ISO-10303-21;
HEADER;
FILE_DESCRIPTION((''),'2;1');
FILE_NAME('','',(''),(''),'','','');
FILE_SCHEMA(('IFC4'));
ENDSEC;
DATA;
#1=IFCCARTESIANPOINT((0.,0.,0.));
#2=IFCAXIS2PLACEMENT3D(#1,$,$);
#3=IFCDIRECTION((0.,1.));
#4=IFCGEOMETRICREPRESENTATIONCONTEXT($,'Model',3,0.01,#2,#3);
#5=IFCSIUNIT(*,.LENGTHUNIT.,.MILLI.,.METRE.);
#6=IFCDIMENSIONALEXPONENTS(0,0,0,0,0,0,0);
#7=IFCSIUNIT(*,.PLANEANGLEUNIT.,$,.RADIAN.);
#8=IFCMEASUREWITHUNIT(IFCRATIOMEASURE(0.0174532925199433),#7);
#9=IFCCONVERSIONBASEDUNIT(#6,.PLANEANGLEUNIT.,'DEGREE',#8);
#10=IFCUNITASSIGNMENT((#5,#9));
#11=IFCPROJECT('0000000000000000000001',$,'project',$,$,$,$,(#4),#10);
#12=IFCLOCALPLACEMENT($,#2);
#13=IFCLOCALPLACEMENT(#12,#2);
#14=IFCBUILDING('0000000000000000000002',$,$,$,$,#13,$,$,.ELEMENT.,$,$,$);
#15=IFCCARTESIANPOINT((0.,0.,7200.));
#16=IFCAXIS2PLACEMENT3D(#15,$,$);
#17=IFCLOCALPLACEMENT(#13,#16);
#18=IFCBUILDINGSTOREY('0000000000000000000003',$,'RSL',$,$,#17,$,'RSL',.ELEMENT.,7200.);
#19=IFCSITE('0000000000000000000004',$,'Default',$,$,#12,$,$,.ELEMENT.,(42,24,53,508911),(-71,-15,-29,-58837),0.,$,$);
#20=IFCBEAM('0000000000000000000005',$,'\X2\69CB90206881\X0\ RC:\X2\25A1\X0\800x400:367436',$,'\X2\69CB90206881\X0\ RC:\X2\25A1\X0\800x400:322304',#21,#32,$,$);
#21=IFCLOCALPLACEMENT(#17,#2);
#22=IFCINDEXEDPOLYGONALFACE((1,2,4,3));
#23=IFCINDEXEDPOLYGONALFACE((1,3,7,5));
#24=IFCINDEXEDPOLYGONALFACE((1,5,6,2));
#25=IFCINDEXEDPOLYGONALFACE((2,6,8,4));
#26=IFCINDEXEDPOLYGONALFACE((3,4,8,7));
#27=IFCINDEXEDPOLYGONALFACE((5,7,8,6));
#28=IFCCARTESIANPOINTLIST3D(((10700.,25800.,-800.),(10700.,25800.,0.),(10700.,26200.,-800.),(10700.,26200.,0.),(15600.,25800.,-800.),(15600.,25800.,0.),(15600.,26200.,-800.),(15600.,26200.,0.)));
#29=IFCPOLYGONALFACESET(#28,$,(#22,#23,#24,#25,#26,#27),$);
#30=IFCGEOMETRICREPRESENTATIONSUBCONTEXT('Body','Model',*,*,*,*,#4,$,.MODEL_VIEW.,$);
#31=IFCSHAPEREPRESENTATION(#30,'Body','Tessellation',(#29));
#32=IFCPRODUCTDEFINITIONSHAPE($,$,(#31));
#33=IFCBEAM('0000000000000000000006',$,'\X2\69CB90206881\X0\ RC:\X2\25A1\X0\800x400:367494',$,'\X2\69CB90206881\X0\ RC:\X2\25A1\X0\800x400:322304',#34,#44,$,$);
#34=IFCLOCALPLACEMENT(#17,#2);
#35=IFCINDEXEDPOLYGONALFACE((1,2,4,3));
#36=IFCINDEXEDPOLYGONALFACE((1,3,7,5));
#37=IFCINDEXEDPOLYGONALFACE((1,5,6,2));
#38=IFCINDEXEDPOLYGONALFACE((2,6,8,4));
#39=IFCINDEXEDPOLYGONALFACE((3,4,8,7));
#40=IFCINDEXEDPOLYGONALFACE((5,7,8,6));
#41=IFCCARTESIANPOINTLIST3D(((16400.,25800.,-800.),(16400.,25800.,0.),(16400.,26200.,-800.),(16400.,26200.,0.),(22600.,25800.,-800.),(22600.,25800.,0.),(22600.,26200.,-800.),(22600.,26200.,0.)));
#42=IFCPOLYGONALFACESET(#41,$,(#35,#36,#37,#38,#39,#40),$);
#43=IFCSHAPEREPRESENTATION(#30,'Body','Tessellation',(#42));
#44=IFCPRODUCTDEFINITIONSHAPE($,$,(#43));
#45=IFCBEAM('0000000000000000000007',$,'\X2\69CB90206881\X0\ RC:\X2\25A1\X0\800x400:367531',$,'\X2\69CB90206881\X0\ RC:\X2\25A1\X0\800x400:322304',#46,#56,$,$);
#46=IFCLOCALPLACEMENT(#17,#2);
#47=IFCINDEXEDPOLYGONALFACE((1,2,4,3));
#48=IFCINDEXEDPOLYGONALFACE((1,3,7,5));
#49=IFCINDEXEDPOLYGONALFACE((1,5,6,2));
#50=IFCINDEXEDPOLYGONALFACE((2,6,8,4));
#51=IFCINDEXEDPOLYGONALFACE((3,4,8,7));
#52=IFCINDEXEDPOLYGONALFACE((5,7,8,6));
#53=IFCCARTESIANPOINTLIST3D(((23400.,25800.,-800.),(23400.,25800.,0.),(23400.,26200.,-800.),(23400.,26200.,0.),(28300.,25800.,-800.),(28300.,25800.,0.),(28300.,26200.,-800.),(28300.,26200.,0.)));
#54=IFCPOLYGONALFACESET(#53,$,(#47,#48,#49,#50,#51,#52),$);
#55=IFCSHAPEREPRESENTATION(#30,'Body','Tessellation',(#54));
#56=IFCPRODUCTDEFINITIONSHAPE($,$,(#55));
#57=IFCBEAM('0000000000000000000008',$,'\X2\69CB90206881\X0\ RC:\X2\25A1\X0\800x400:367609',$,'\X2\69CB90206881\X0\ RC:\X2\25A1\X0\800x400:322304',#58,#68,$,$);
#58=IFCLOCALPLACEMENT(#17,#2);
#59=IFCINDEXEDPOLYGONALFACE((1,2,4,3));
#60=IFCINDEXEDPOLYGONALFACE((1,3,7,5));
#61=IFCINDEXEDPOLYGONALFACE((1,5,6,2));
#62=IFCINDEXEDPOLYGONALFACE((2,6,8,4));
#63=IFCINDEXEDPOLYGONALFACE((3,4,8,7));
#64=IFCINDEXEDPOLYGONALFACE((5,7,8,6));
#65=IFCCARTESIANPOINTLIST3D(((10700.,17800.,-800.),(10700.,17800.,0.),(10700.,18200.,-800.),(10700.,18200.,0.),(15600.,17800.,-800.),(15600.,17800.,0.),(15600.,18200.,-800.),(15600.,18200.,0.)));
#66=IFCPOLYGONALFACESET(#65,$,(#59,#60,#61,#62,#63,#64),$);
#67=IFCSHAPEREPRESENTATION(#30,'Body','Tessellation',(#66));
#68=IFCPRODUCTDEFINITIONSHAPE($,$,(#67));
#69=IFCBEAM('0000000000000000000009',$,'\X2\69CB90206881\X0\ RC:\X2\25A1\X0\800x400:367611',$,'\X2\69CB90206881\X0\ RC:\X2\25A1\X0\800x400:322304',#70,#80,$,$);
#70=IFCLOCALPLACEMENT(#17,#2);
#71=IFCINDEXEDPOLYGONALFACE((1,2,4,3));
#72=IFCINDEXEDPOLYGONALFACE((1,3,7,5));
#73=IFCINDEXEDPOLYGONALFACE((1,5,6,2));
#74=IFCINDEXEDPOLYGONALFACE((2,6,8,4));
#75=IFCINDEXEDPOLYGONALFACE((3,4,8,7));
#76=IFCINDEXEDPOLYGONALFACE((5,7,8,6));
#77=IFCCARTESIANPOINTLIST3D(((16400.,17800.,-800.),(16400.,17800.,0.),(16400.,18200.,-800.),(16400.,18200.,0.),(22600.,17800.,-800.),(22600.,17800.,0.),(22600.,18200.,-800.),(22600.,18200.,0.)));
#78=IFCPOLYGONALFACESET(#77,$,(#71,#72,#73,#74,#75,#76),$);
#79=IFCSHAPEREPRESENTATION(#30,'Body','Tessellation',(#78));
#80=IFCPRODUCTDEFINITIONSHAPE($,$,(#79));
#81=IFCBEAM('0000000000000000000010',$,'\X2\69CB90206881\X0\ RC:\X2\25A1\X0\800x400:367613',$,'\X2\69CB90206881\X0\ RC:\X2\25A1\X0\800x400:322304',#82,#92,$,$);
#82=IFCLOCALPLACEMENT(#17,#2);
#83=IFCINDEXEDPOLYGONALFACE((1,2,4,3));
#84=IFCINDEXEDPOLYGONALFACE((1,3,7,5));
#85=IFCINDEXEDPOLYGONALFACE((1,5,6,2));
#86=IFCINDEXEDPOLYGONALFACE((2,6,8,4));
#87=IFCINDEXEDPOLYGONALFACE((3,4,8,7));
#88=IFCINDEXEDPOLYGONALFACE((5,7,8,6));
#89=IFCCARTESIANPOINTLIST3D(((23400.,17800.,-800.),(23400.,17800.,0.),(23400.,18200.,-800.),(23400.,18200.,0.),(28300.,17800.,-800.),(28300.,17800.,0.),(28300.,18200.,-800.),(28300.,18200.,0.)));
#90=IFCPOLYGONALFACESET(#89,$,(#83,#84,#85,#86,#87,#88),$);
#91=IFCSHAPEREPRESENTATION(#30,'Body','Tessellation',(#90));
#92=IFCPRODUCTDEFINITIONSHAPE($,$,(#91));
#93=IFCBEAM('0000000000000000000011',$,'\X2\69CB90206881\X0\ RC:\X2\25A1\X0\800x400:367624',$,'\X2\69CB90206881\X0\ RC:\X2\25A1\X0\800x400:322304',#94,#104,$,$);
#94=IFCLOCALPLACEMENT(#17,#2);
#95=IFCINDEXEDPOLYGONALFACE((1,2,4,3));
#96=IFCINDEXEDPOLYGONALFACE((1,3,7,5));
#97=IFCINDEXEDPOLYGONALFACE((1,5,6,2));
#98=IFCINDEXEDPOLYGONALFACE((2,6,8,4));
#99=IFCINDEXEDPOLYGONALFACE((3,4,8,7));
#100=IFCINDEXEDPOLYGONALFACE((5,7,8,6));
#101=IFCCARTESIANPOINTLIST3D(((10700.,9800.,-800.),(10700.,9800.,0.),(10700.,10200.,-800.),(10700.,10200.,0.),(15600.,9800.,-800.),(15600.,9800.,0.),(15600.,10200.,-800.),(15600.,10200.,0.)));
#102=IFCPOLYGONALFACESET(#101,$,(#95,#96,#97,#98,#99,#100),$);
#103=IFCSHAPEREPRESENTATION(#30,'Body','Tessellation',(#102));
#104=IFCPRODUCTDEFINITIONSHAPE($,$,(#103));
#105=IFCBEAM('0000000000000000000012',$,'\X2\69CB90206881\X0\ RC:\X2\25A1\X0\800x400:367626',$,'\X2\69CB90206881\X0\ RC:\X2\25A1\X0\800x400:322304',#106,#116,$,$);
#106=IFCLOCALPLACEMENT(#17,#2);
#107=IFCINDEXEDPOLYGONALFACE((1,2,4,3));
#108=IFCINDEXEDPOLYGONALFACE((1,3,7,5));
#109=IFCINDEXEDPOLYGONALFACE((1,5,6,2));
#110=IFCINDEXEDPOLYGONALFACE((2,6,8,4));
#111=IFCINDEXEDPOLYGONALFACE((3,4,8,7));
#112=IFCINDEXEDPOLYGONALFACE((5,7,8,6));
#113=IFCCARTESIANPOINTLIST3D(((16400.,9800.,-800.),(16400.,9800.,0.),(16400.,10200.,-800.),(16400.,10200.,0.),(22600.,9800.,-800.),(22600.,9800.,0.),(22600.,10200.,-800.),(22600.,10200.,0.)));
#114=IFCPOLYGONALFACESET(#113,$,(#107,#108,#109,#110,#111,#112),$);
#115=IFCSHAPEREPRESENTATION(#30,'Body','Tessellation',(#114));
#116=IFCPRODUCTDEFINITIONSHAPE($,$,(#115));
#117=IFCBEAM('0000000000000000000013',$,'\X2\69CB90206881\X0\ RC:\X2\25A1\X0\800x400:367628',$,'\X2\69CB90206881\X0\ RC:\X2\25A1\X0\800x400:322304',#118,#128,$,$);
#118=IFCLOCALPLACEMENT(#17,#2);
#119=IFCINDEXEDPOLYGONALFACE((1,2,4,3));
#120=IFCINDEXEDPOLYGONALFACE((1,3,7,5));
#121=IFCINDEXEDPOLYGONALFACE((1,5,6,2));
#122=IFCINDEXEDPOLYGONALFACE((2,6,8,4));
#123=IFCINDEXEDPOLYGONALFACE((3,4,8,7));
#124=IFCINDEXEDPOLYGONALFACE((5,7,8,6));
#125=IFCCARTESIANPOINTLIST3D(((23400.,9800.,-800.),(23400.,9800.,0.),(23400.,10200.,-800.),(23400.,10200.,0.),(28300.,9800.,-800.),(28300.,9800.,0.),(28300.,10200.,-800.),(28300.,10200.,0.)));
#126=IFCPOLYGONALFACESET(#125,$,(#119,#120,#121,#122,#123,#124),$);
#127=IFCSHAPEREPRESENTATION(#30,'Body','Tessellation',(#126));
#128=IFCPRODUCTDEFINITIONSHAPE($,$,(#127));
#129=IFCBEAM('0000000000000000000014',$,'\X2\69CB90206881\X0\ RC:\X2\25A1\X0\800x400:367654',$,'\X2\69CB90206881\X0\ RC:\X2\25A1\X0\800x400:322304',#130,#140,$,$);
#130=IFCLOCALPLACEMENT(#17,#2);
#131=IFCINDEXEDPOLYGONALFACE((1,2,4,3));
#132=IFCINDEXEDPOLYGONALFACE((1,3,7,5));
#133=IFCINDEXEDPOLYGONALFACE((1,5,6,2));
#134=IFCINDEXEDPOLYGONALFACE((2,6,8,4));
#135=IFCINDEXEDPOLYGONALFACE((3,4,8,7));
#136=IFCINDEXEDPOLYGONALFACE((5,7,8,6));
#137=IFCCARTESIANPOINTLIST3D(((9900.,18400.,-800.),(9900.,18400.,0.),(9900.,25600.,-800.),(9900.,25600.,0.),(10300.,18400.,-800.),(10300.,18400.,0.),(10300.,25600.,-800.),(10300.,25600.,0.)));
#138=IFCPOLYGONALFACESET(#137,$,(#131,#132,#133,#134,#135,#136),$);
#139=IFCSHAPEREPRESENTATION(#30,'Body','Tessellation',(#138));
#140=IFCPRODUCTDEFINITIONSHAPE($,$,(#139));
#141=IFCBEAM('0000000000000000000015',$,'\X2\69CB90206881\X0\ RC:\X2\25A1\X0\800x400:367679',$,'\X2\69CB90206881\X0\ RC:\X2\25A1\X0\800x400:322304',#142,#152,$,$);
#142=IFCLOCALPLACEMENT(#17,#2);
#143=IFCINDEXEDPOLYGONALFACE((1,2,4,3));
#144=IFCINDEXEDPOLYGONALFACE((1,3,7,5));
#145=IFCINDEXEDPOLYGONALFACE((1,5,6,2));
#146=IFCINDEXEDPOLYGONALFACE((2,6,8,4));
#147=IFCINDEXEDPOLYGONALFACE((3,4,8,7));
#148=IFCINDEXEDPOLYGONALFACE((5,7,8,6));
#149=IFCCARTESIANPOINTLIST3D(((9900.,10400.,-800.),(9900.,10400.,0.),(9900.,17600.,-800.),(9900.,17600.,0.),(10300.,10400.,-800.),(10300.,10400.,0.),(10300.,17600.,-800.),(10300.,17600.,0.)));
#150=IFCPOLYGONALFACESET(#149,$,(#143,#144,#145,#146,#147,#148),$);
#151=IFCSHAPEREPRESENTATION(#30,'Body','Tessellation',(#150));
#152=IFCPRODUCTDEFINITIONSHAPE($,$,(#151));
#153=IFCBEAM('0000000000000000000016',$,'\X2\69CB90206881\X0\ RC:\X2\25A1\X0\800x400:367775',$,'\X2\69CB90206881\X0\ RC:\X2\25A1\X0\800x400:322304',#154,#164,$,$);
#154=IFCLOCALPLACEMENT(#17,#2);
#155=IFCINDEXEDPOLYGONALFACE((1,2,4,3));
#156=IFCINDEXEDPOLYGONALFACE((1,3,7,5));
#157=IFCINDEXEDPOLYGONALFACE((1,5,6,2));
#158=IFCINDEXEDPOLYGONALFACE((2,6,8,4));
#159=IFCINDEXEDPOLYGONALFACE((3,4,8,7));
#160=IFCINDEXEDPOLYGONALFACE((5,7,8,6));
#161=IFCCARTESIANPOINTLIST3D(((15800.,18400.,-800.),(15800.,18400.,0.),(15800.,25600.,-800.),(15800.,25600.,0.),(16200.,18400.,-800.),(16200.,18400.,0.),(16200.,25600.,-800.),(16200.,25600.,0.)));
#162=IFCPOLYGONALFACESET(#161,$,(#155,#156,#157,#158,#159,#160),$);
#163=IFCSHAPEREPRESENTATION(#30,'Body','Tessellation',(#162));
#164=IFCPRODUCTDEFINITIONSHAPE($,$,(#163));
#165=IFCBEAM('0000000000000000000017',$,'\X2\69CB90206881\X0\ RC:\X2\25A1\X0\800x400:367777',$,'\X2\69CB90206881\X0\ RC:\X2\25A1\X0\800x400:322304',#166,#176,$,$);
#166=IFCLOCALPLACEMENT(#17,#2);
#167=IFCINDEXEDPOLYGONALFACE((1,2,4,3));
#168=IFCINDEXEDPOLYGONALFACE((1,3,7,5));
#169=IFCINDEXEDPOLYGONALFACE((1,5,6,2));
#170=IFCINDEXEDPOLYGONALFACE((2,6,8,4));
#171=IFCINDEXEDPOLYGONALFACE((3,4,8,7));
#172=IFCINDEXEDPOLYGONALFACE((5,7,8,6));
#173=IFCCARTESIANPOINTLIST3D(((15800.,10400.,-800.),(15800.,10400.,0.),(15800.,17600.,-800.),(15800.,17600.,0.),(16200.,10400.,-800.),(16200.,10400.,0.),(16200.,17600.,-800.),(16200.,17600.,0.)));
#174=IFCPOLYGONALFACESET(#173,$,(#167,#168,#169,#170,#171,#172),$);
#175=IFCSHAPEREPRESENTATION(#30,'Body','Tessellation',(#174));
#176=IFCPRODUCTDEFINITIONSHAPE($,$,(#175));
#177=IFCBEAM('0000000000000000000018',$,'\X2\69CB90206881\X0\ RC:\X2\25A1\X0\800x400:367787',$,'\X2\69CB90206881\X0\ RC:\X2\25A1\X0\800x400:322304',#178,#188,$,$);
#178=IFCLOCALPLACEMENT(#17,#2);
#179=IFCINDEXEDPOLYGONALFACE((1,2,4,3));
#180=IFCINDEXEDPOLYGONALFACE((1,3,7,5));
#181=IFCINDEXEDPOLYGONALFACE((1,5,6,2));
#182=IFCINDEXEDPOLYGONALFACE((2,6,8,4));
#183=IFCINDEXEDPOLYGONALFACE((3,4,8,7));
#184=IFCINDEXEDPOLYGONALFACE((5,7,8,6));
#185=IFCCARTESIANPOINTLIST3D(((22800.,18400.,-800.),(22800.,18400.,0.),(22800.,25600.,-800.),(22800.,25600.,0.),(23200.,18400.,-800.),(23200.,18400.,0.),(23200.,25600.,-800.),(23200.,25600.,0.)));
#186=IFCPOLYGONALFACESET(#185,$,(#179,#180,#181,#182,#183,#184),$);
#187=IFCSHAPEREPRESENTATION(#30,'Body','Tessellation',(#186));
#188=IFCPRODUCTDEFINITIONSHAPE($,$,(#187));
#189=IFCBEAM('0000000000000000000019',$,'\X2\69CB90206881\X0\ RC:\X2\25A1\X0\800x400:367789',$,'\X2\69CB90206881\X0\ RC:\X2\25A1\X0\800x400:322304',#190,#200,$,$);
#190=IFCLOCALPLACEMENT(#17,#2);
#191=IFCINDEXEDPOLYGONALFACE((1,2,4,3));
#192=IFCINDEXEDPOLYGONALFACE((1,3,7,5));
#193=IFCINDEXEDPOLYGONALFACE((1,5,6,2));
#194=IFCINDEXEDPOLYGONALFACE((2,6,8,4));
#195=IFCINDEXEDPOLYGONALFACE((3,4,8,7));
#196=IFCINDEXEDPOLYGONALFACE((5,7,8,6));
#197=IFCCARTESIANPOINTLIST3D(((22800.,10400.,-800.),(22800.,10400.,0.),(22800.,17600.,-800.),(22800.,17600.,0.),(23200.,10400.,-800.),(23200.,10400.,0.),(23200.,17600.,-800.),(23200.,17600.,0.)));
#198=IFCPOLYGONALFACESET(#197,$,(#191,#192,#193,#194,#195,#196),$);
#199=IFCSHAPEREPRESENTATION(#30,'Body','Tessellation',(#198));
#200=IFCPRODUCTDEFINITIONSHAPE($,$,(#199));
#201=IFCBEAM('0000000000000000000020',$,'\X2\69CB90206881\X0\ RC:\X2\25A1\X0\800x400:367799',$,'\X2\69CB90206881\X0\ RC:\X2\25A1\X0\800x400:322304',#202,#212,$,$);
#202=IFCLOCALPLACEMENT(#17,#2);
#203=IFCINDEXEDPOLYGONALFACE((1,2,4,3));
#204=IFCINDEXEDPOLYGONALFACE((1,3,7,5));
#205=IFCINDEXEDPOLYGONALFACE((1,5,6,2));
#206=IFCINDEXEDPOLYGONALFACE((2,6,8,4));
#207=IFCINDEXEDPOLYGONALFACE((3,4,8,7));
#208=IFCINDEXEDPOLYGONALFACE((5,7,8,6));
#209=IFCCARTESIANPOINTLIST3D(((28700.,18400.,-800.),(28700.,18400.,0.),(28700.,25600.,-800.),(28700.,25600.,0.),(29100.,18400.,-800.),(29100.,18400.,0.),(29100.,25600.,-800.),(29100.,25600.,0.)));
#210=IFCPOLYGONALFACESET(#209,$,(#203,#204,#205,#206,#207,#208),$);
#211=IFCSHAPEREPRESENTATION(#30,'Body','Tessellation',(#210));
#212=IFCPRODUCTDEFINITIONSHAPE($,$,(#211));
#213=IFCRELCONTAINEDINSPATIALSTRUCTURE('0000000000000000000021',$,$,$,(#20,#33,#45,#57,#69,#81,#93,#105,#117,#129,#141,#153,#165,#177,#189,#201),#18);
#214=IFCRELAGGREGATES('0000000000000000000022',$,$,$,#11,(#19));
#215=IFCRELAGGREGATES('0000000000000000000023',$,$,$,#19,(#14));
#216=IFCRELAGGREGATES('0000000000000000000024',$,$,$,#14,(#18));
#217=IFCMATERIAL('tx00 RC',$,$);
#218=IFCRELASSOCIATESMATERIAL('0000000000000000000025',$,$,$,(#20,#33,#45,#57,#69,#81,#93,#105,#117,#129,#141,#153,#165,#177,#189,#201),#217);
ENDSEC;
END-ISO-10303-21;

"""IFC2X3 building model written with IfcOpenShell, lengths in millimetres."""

from ifc_helpers import new_model, entity, si_unit, converted_unit, direction, frame, frame_2d, origin, place, context, subcontext, project, spatial, rectangle, extrude, material, element, save


model = new_model("IFC2X3")

# Units and contexts
model_context = context("Model", 3, precision=0.01, world=origin(), true_north=direction((0.0, 1.0)))
body_context = subcontext(model_context, "Body", "Model", "MODEL_VIEW")
ifc_project = project(units=[si_unit("LENGTHUNIT", "METRE", prefix="MILLI"), converted_unit("PLANEANGLEUNIT", "DEGREE", entity("IfcRatioMeasure", 0.0174532925199433), si_unit("PLANEANGLEUNIT", "RADIAN"), dimensions=[0, 0, 0, 0, 0, 0, 0])], contexts=[model_context])

# Site, building, storey
site_placement = place(None, origin())
site = spatial("IfcSite", under=ifc_project, at=site_placement, Name="Default", CompositionType="ELEMENT", RefLatitude=(42, 24, 53, 508911), RefLongitude=(-71, -15, -29, -58837), RefElevation=0.0)
building_placement = place(site_placement, origin())
building = spatial("IfcBuilding", under=site, at=building_placement, CompositionType="ELEMENT")
storey_placement = place(building_placement, frame((0.0, 0.0, 7200.0)))
storey = spatial("IfcBuildingStorey", under=building, at=storey_placement, Name="RSL", LongName="RSL", CompositionType="ELEMENT", Elevation=7200.0)

# Beams
ifc_material_1 = material(Name="tx00 RC")
beam_1_placement = place(storey_placement, frame((10300.0, 26000.0, 0.0)))
element("IfcBeam", 1, at=beam_1_placement, inside=storey, material=ifc_material_1, Name="構造梁 RC:□800x400:367436", ObjectType="構造梁 RC:□800x400:322304", context=body_context, shape_type="SweptSolid", body=[
    extrude(rectangle(XDim=800.0, YDim=400.0, at=frame_2d((0.0, 0.0), x_axis=(1.0, 0.0))), frame((400.0, 0.0, -400.0), z_axis=(1.0, 0.0, 0.0), x_axis=(0.0, 0.0, -1.0)), (0.0, 0.0, 1.0), 4900.0),
])
beam_2_placement = place(storey_placement, frame((16000.0, 26000.0, 0.0)))
element("IfcBeam", 2, at=beam_2_placement, inside=storey, material=ifc_material_1, Name="構造梁 RC:□800x400:367494", ObjectType="構造梁 RC:□800x400:322304", context=body_context, shape_type="SweptSolid", body=[
    extrude(rectangle(XDim=800.0, YDim=400.0, at=frame_2d((0.0, 0.0), x_axis=(1.0, 0.0))), frame((400.0, 0.0, -400.0), z_axis=(1.0, 0.0, 0.0), x_axis=(0.0, 0.0, -1.0)), (0.0, 0.0, 1.0), 6200.0),
])
beam_3_placement = place(storey_placement, frame((23000.0, 26000.0, 0.0)))
element("IfcBeam", 3, at=beam_3_placement, inside=storey, material=ifc_material_1, Name="構造梁 RC:□800x400:367531", ObjectType="構造梁 RC:□800x400:322304", context=body_context, shape_type="SweptSolid", body=[
    extrude(rectangle(XDim=800.0, YDim=400.0, at=frame_2d((0.0, 0.0), x_axis=(1.0, 0.0))), frame((400.0, 0.0, -400.0), z_axis=(1.0, 0.0, 0.0), x_axis=(0.0, 0.0, -1.0)), (0.0, 0.0, 1.0), 4900.0),
])
beam_4_placement = place(storey_placement, frame((10300.0, 18000.0, 0.0)))
element("IfcBeam", 4, at=beam_4_placement, inside=storey, material=ifc_material_1, Name="構造梁 RC:□800x400:367609", ObjectType="構造梁 RC:□800x400:322304", context=body_context, shape_type="SweptSolid", body=[
    extrude(rectangle(XDim=800.0, YDim=400.0, at=frame_2d((0.0, 0.0), x_axis=(1.0, 0.0))), frame((400.0, 0.0, -400.0), z_axis=(1.0, 0.0, 0.0), x_axis=(0.0, 0.0, -1.0)), (0.0, 0.0, 1.0), 4900.0),
])
beam_5_placement = place(storey_placement, frame((16000.0, 18000.0, 0.0)))
element("IfcBeam", 5, at=beam_5_placement, inside=storey, material=ifc_material_1, Name="構造梁 RC:□800x400:367611", ObjectType="構造梁 RC:□800x400:322304", context=body_context, shape_type="SweptSolid", body=[
    extrude(rectangle(XDim=800.0, YDim=400.0, at=frame_2d((0.0, 0.0), x_axis=(1.0, 0.0))), frame((400.0, 0.0, -400.0), z_axis=(1.0, 0.0, 0.0), x_axis=(0.0, 0.0, -1.0)), (0.0, 0.0, 1.0), 6200.0),
])
beam_6_placement = place(storey_placement, frame((23000.0, 18000.0, 0.0)))
element("IfcBeam", 6, at=beam_6_placement, inside=storey, material=ifc_material_1, Name="構造梁 RC:□800x400:367613", ObjectType="構造梁 RC:□800x400:322304", context=body_context, shape_type="SweptSolid", body=[
    extrude(rectangle(XDim=800.0, YDim=400.0, at=frame_2d((0.0, 0.0), x_axis=(1.0, 0.0))), frame((400.0, 0.0, -400.0), z_axis=(1.0, 0.0, 0.0), x_axis=(0.0, 0.0, -1.0)), (0.0, 0.0, 1.0), 4900.0),
])
beam_7_placement = place(storey_placement, frame((10300.0, 10000.0, 0.0)))
element("IfcBeam", 7, at=beam_7_placement, inside=storey, material=ifc_material_1, Name="構造梁 RC:□800x400:367624", ObjectType="構造梁 RC:□800x400:322304", context=body_context, shape_type="SweptSolid", body=[
    extrude(rectangle(XDim=800.0, YDim=400.0, at=frame_2d((0.0, 0.0), x_axis=(1.0, 0.0))), frame((400.0, 0.0, -400.0), z_axis=(1.0, 0.0, 0.0), x_axis=(0.0, 0.0, -1.0)), (0.0, 0.0, 1.0), 4900.0),
])
beam_8_placement = place(storey_placement, frame((16000.0, 10000.0, 0.0)))
element("IfcBeam", 8, at=beam_8_placement, inside=storey, material=ifc_material_1, Name="構造梁 RC:□800x400:367626", ObjectType="構造梁 RC:□800x400:322304", context=body_context, shape_type="SweptSolid", body=[
    extrude(rectangle(XDim=800.0, YDim=400.0, at=frame_2d((0.0, 0.0), x_axis=(1.0, 0.0))), frame((400.0, 0.0, -400.0), z_axis=(1.0, 0.0, 0.0), x_axis=(0.0, 0.0, -1.0)), (0.0, 0.0, 1.0), 6200.0),
])
beam_9_placement = place(storey_placement, frame((23000.0, 10000.0, 0.0)))
element("IfcBeam", 9, at=beam_9_placement, inside=storey, material=ifc_material_1, Name="構造梁 RC:□800x400:367628", ObjectType="構造梁 RC:□800x400:322304", context=body_context, shape_type="SweptSolid", body=[
    extrude(rectangle(XDim=800.0, YDim=400.0, at=frame_2d((0.0, 0.0), x_axis=(1.0, 0.0))), frame((400.0, 0.0, -400.0), z_axis=(1.0, 0.0, 0.0), x_axis=(0.0, 0.0, -1.0)), (0.0, 0.0, 1.0), 4900.0),
])
for number, where, z_axis, x_axis, name in (
    (10, (10100.0, 26000.0, 0.0), (0.0, 0.0, 1.0), (0.0, -1.0, 0.0), "構造梁 RC:□800x400:367654"),
    (11, (10100.0, 18000.0, 0.0), (0.0, 0.0, 1.0), (0.0, -1.0, 0.0), "構造梁 RC:□800x400:367679"),
    (12, (16000.0, 26000.0, 0.0), (0.0, 0.0, 1.0), (0.0, -1.0, 0.0), "構造梁 RC:□800x400:367775"),
    (13, (16000.0, 18000.0, 0.0), (0.0, 0.0, 1.0), (0.0, -1.0, 0.0), "構造梁 RC:□800x400:367777"),
):
    element("IfcBeam", number, at=place(storey_placement, frame(where, z_axis=z_axis, x_axis=x_axis)), inside=storey, material=ifc_material_1, Name=name, ObjectType="構造梁 RC:□800x400:322304", context=body_context, shape_type="SweptSolid", body=[
        extrude(rectangle(XDim=800.0, YDim=400.0, at=frame_2d((0.0, 0.0), x_axis=(1.0, 0.0))), frame((400.0, 0.0, -400.0), z_axis=(1.0, 0.0, 0.0), x_axis=(0.0, 0.0, -1.0)), (0.0, 0.0, 1.0), 7200.0),
    ])
beam_10_placement = place(storey_placement, frame((23000.0, 26000.0, 0.0), z_axis=(0.0, 0.0, 1.0), x_axis=(0.0, -1.0, 0.0)))
element("IfcBeam", 14, at=beam_10_placement, inside=storey, material=ifc_material_1, Name="構造梁 RC:□800x400:367787", ObjectType="構造梁 RC:□800x400:322304", context=body_context, shape_type="SweptSolid", body=[
    extrude(rectangle(XDim=800.0, YDim=400.0, at=frame_2d((0.0, 0.0), x_axis=(1.0, 0.0))), frame((400.0, 0.0, -400.0), z_axis=(1.0, 0.0, 0.0), x_axis=(0.0, 0.0, -1.0)), (0.0, 0.0, 1.0), 7200.0),
])
beam_11_placement = place(storey_placement, frame((23000.0, 18000.0, 0.0), z_axis=(0.0, 0.0, 1.0), x_axis=(0.0, -1.0, 0.0)))
element("IfcBeam", 15, at=beam_11_placement, inside=storey, material=ifc_material_1, Name="構造梁 RC:□800x400:367789", ObjectType="構造梁 RC:□800x400:322304", context=body_context, shape_type="SweptSolid", body=[
    extrude(rectangle(XDim=800.0, YDim=400.0, at=frame_2d((0.0, 0.0), x_axis=(1.0, 0.0))), frame((400.0, 0.0, -400.0), z_axis=(1.0, 0.0, 0.0), x_axis=(0.0, 0.0, -1.0)), (0.0, 0.0, 1.0), 7200.0),
])
beam_12_placement = place(storey_placement, frame((28900.0, 26000.0, 0.0), z_axis=(0.0, 0.0, 1.0), x_axis=(0.0, -1.0, 0.0)))
element("IfcBeam", 16, at=beam_12_placement, inside=storey, material=ifc_material_1, Name="構造梁 RC:□800x400:367799", ObjectType="構造梁 RC:□800x400:322304", context=body_context, shape_type="SweptSolid", body=[
    extrude(rectangle(XDim=800.0, YDim=400.0, at=frame_2d((0.0, 0.0), x_axis=(1.0, 0.0))), frame((400.0, 0.0, -400.0), z_axis=(1.0, 0.0, 0.0), x_axis=(0.0, 0.0, -1.0)), (0.0, 0.0, 1.0), 7200.0),
])

save(model, "model.ifc")
